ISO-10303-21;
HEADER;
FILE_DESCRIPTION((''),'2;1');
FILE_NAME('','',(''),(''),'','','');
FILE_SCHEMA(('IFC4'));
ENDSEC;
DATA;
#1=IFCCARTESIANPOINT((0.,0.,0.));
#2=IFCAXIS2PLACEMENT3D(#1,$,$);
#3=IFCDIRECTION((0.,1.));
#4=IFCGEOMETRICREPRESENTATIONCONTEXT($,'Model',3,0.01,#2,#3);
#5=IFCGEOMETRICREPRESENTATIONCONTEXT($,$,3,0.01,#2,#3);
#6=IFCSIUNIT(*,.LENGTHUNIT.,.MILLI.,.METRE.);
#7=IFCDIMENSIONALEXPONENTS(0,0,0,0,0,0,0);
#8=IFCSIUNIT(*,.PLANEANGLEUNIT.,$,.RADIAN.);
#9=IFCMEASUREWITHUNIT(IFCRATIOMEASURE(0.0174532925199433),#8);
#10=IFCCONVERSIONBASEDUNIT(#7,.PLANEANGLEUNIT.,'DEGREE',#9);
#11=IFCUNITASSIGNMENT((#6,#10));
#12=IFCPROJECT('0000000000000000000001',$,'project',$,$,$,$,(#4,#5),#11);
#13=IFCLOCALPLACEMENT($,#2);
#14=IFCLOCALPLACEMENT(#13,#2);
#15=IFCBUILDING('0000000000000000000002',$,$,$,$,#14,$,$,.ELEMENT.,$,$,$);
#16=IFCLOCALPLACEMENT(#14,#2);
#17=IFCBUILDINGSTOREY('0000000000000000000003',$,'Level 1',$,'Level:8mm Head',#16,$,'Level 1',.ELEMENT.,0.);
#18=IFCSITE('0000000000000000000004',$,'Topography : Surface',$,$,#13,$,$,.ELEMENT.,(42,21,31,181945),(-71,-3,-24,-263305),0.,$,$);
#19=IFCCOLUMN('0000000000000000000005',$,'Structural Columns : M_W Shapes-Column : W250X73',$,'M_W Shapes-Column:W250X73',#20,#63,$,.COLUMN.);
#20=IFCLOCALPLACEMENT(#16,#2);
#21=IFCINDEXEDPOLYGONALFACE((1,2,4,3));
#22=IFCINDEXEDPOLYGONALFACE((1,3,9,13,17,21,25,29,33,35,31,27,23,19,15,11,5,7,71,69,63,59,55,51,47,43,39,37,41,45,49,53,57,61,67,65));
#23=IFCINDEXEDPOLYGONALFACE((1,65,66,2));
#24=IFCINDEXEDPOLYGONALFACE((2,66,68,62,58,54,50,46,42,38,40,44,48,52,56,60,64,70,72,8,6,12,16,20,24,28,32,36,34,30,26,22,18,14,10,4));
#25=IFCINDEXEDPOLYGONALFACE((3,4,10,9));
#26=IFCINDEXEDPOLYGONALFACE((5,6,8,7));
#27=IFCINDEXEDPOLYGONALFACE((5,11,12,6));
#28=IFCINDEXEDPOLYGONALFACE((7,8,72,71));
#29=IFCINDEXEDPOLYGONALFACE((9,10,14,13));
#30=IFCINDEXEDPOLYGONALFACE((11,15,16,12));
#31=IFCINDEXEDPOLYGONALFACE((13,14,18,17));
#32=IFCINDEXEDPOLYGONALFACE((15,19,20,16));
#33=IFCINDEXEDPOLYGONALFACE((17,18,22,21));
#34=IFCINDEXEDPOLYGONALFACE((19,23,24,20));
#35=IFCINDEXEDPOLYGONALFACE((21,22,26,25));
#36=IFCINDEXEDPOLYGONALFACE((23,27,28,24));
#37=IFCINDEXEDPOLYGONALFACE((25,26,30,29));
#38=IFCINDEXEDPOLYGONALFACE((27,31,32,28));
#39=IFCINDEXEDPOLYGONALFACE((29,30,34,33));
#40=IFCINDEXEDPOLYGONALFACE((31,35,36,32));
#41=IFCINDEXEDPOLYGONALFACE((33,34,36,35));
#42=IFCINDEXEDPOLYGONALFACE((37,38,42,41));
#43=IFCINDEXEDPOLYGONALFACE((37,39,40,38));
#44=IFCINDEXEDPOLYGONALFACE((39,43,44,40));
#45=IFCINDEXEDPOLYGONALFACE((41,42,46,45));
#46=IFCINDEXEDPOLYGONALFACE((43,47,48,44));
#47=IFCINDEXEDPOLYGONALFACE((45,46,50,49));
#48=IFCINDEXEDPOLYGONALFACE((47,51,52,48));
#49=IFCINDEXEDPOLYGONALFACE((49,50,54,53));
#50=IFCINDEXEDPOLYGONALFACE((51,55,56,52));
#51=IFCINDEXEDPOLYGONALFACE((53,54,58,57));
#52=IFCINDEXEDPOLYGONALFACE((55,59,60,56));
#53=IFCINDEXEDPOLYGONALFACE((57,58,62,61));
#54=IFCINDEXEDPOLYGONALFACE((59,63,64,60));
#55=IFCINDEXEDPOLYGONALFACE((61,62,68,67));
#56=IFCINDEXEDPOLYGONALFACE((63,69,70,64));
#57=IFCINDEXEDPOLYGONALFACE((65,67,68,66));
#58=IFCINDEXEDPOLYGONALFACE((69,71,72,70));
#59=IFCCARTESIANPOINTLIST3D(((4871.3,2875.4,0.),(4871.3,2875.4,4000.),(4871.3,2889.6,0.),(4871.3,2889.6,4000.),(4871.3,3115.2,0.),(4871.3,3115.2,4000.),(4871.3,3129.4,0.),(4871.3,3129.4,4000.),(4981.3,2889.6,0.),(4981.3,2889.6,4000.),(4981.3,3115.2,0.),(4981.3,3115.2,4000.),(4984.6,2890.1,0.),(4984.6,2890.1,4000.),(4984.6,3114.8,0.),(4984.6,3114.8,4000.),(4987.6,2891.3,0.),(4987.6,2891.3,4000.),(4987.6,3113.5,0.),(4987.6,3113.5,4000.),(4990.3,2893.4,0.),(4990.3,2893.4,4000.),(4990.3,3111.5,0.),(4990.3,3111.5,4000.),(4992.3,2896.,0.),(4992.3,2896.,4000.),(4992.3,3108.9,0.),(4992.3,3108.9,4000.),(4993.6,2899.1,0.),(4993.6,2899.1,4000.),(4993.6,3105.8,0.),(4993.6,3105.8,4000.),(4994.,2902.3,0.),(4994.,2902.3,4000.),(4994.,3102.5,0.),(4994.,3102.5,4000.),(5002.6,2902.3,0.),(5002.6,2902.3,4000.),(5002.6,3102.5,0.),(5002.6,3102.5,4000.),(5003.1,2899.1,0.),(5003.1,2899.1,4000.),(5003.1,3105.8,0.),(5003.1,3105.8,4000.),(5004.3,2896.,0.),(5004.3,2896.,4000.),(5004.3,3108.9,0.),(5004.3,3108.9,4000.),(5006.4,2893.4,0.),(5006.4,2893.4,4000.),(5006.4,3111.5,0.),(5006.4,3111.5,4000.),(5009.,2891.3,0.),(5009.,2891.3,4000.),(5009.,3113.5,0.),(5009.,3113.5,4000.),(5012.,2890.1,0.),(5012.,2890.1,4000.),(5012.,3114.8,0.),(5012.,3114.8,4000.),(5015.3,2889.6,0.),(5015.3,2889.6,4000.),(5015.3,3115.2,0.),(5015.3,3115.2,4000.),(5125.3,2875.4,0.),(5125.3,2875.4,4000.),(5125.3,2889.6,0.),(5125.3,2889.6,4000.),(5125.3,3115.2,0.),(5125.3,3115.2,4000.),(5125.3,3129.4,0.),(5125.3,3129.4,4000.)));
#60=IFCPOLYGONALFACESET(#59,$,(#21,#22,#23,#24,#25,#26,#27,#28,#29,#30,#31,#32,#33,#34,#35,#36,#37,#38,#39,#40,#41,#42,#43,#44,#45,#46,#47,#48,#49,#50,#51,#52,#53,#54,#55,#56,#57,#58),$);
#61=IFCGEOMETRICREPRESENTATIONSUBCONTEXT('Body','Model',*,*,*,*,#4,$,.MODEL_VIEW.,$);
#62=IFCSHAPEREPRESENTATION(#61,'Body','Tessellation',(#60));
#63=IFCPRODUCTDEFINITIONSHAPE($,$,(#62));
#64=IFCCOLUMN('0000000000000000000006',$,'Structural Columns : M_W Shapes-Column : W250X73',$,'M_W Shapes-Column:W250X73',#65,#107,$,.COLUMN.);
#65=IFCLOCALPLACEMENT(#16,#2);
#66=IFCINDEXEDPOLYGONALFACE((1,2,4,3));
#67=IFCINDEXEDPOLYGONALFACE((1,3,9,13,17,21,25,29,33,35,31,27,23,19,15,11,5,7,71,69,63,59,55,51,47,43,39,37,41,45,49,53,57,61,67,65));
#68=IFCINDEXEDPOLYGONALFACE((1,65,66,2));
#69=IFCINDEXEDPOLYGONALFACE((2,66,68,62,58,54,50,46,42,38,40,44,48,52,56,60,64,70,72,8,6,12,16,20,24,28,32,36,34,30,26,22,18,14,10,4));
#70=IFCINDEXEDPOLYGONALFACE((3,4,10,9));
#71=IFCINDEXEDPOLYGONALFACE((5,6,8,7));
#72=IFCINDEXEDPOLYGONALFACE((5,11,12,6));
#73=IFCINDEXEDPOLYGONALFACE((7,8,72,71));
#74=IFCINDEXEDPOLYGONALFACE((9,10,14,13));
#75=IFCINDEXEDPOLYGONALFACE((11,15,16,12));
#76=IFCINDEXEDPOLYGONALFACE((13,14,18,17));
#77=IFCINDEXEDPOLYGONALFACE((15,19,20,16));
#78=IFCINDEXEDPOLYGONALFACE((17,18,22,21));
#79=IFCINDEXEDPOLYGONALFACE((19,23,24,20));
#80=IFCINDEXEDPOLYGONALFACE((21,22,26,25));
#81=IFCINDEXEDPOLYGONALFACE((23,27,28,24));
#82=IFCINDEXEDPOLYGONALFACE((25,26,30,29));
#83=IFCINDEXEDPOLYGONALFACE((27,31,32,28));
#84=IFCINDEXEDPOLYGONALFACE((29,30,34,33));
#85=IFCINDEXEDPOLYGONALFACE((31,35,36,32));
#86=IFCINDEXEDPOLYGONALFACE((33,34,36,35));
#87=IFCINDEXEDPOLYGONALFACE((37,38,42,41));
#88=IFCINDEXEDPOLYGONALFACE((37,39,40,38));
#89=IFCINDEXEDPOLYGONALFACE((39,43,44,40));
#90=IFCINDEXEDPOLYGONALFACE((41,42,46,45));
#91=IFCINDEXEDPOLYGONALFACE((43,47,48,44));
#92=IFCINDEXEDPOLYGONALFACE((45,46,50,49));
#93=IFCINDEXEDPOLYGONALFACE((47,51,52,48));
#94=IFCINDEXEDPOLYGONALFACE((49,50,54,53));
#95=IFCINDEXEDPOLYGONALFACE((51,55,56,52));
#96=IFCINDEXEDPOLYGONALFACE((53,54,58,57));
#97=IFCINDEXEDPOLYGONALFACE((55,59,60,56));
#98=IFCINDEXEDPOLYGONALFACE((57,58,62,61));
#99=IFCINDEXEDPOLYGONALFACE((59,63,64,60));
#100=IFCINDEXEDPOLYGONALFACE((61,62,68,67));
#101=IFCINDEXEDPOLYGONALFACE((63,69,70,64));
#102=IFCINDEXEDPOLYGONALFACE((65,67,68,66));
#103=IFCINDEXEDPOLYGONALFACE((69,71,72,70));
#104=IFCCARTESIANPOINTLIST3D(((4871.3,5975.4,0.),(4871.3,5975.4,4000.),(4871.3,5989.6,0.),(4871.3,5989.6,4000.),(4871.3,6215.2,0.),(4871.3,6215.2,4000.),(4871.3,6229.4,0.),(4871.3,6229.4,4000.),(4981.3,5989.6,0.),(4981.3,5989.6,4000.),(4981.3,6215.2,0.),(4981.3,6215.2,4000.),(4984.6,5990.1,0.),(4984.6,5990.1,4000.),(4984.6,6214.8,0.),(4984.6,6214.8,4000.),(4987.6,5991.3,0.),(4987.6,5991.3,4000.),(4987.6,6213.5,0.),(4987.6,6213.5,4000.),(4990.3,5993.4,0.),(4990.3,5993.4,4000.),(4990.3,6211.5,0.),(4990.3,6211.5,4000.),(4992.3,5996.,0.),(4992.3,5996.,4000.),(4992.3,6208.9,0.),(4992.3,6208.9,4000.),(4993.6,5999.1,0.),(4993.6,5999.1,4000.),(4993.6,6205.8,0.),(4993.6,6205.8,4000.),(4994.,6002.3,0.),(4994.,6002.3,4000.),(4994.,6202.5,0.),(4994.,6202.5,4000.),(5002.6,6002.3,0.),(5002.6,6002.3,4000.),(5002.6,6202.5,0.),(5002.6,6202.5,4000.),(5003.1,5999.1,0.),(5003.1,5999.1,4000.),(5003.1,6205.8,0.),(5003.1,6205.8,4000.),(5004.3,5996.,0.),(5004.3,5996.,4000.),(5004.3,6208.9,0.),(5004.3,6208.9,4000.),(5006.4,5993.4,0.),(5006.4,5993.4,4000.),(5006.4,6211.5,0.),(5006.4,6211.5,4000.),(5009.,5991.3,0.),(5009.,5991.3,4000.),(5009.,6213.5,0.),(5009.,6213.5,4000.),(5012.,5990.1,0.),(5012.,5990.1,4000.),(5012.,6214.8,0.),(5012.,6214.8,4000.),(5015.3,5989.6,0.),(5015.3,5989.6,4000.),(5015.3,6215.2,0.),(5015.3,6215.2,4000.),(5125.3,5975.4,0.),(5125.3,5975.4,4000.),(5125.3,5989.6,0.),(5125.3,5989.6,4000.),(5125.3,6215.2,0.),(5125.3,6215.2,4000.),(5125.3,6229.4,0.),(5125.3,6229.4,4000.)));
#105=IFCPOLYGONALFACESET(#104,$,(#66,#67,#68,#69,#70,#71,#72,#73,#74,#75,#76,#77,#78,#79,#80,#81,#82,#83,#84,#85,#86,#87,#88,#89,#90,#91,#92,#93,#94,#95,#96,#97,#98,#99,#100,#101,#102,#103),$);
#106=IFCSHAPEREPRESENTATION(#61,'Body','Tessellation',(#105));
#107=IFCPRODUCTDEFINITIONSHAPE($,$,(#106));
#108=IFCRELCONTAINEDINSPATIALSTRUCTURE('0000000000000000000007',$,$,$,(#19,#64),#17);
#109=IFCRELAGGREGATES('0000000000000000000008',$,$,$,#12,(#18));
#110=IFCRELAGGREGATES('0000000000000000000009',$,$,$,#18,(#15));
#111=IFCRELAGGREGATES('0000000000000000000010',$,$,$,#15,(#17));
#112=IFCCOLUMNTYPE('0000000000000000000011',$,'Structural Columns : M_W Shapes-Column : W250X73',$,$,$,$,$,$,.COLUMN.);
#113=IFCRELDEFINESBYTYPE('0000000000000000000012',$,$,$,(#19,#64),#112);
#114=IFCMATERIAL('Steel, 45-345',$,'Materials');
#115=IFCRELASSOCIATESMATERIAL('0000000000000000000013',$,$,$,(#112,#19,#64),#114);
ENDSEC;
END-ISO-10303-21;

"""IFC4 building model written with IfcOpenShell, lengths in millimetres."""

from ifc_helpers import new_model, entity, si_unit, converted_unit, direction, frame, frame_2d, origin, place, context, subcontext, project, spatial, polyline, circle_curve, parameter, trimmed, segment, composite_curve, outline, extrude, source, transform, mapped, material, material_profile, profile_set, profile_usage, type_object, type_shapes, element, save


model = new_model("IFC4")

# Units and contexts
model_context = context("Model", 3, precision=0.01, world=origin(), true_north=direction((0.0, 1.0)))
context_of_model = context(None, 3, precision=0.01, world=origin(), true_north=direction((0.0, 1.0)))
body_context = subcontext(model_context, "Body", "Model", "MODEL_VIEW")
ifc_project = project(units=[si_unit("LENGTHUNIT", "METRE", prefix="MILLI"), converted_unit("PLANEANGLEUNIT", "DEGREE", entity("IfcRatioMeasure", 0.0174532925199433), si_unit("PLANEANGLEUNIT", "RADIAN"), dimensions=[0, 0, 0, 0, 0, 0, 0])], contexts=[model_context, context_of_model])

# Site, building, storey
site_placement = place(None, origin())
site = spatial("IfcSite", under=ifc_project, at=site_placement, Name="Topography : Surface", CompositionType="ELEMENT", RefLatitude=(42, 21, 31, 181945), RefLongitude=(-71, -3, -24, -263305), RefElevation=0.0)
building_placement = place(site_placement, origin())
building = spatial("IfcBuilding", under=site, at=building_placement, CompositionType="ELEMENT")
storey_placement = place(building_placement, origin())
storey = spatial("IfcBuildingStorey", under=building, at=storey_placement, Name="Level 1", ObjectType="Level:8mm Head", LongName="Level 1", CompositionType="ELEMENT", Elevation=0.0)

# Columns
ifc_material_1 = material(Name="Steel, 45-345", Category="Materials")
ifc_material_profile = material_profile(ifc_material_1, outline(composite_curve([segment(polyline([(112.8, -127.0), (127.0, -127.0)]), True, "CONTINUOUS"), segment(polyline([(127.0, -127.0), (127.0, 127.0)]), True, "CONTINUOUS"), segment(polyline([(127.0, 127.0), (112.8, 127.0)]), True, "CONTINUOUS"), segment(polyline([(112.8, 127.0), (112.8, 17.0)]), True, "CONTINUOUS"), segment(trimmed(circle_curve(frame_2d((100.1, 17.0), x_axis=(1.0, 0.0)), 12.7), [parameter(270.0)], [parameter(0.0)], True, "PARAMETER"), False, "CONTINUOUS"), segment(polyline([(100.1, 4.3), (-100.1, 4.3)]), True, "CONTINUOUS"), segment(trimmed(circle_curve(frame_2d((-100.1, 17.0), x_axis=(0.0, -1.0)), 12.7), [parameter(270.0)], [parameter(0.0)], True, "PARAMETER"), False, "CONTINUOUS"), segment(polyline([(-112.8, 17.0), (-112.8, 127.0)]), True, "CONTINUOUS"), segment(polyline([(-112.8, 127.0), (-127.0, 127.0)]), True, "CONTINUOUS"), segment(polyline([(-127.0, 127.0), (-127.0, -127.0)]), True, "CONTINUOUS"), segment(polyline([(-127.0, -127.0), (-112.8, -127.0)]), True, "CONTINUOUS"), segment(polyline([(-112.8, -127.0), (-112.8, -17.0)]), True, "CONTINUOUS"), segment(trimmed(circle_curve(frame_2d((-100.1, -17.0), x_axis=(-1.0, 0.0)), 12.7), [parameter(270.0)], [parameter(0.0)], True, "PARAMETER"), False, "CONTINUOUS"), segment(polyline([(-100.1, -4.3), (100.1, -4.3)]), True, "CONTINUOUS"), segment(trimmed(circle_curve(frame_2d((100.1, -17.0), x_axis=(0.0, 1.0)), 12.7), [parameter(270.0)], [parameter(0.0)], True, "PARAMETER"), False, "CONTINUOUS"), segment(polyline([(112.8, -17.0), (112.8, -127.0)]), True, "CONTINUOUS")], self_intersect=False)), Name="W250X73")
ifc_profile_set = profile_set([ifc_material_profile], Name="W250X73")
ifc_profile_usage_1 = profile_usage(ifc_profile_set)
column_type = type_object("IfcColumnType", Name="Structural Columns : M_W Shapes-Column : W250X73", PredefinedType="COLUMN", material=ifc_profile_set)
shared_shape = source(origin(), body_context, "Body", "SweptSolid", [
    extrude(outline(composite_curve([segment(polyline([(112.8, -127.0), (127.0, -127.0)]), True, "CONTINUOUS"), segment(polyline([(127.0, -127.0), (127.0, 127.0)]), True, "CONTINUOUS"), segment(polyline([(127.0, 127.0), (112.8, 127.0)]), True, "CONTINUOUS"), segment(polyline([(112.8, 127.0), (112.8, 17.0)]), True, "CONTINUOUS"), segment(trimmed(circle_curve(frame_2d((100.1, 17.0), x_axis=(1.0, 0.0)), 12.7), [parameter(270.0)], [parameter(0.0)], True, "PARAMETER"), False, "CONTINUOUS"), segment(polyline([(100.1, 4.3), (-100.1, 4.3)]), True, "CONTINUOUS"), segment(trimmed(circle_curve(frame_2d((-100.1, 17.0), x_axis=(0.0, -1.0)), 12.7), [parameter(270.0)], [parameter(0.0)], True, "PARAMETER"), False, "CONTINUOUS"), segment(polyline([(-112.8, 17.0), (-112.8, 127.0)]), True, "CONTINUOUS"), segment(polyline([(-112.8, 127.0), (-127.0, 127.0)]), True, "CONTINUOUS"), segment(polyline([(-127.0, 127.0), (-127.0, -127.0)]), True, "CONTINUOUS"), segment(polyline([(-127.0, -127.0), (-112.8, -127.0)]), True, "CONTINUOUS"), segment(polyline([(-112.8, -127.0), (-112.8, -17.0)]), True, "CONTINUOUS"), segment(trimmed(circle_curve(frame_2d((-100.1, -17.0), x_axis=(-1.0, 0.0)), 12.7), [parameter(270.0)], [parameter(0.0)], True, "PARAMETER"), False, "CONTINUOUS"), segment(polyline([(-100.1, -4.3), (100.1, -4.3)]), True, "CONTINUOUS"), segment(trimmed(circle_curve(frame_2d((100.1, -17.0), x_axis=(0.0, 1.0)), 12.7), [parameter(270.0)], [parameter(0.0)], True, "PARAMETER"), False, "CONTINUOUS"), segment(polyline([(112.8, -17.0), (112.8, -127.0)]), True, "CONTINUOUS")], self_intersect=False)), frame((0.0, 0.0, 0.0), z_axis=(0.0, 0.0, 1.0), x_axis=(0.0, -1.0, 0.0)), (0.0, 0.0, 1.0), 4000.0),
])
type_shapes(column_type, [shared_shape])
column_1_placement = place(storey_placement, frame((4998.3, 3002.4, 0.0)))
element("IfcColumn", 1, at=column_1_placement, inside=storey, type_object=column_type, material=ifc_profile_usage_1, Name="Structural Columns : M_W Shapes-Column : W250X73", ObjectType="M_W Shapes-Column:W250X73", PredefinedType="COLUMN", context=body_context, shape_type="MappedRepresentation", body=[
    mapped(shared_shape, transform((0.0, 0.0, 0.0), scale=1.0)),
])
ifc_profile_usage_2 = profile_usage(ifc_profile_set)
column_2_placement = place(storey_placement, frame((4998.3, 6102.4, 0.0)))
element("IfcColumn", 2, at=column_2_placement, inside=storey, type_object=column_type, material=ifc_profile_usage_2, Name="Structural Columns : M_W Shapes-Column : W250X73", ObjectType="M_W Shapes-Column:W250X73", PredefinedType="COLUMN", context=body_context, shape_type="MappedRepresentation", body=[
    mapped(shared_shape, transform((0.0, 0.0, 0.0), scale=1.0)),
])

save(model, "model.ifc")
